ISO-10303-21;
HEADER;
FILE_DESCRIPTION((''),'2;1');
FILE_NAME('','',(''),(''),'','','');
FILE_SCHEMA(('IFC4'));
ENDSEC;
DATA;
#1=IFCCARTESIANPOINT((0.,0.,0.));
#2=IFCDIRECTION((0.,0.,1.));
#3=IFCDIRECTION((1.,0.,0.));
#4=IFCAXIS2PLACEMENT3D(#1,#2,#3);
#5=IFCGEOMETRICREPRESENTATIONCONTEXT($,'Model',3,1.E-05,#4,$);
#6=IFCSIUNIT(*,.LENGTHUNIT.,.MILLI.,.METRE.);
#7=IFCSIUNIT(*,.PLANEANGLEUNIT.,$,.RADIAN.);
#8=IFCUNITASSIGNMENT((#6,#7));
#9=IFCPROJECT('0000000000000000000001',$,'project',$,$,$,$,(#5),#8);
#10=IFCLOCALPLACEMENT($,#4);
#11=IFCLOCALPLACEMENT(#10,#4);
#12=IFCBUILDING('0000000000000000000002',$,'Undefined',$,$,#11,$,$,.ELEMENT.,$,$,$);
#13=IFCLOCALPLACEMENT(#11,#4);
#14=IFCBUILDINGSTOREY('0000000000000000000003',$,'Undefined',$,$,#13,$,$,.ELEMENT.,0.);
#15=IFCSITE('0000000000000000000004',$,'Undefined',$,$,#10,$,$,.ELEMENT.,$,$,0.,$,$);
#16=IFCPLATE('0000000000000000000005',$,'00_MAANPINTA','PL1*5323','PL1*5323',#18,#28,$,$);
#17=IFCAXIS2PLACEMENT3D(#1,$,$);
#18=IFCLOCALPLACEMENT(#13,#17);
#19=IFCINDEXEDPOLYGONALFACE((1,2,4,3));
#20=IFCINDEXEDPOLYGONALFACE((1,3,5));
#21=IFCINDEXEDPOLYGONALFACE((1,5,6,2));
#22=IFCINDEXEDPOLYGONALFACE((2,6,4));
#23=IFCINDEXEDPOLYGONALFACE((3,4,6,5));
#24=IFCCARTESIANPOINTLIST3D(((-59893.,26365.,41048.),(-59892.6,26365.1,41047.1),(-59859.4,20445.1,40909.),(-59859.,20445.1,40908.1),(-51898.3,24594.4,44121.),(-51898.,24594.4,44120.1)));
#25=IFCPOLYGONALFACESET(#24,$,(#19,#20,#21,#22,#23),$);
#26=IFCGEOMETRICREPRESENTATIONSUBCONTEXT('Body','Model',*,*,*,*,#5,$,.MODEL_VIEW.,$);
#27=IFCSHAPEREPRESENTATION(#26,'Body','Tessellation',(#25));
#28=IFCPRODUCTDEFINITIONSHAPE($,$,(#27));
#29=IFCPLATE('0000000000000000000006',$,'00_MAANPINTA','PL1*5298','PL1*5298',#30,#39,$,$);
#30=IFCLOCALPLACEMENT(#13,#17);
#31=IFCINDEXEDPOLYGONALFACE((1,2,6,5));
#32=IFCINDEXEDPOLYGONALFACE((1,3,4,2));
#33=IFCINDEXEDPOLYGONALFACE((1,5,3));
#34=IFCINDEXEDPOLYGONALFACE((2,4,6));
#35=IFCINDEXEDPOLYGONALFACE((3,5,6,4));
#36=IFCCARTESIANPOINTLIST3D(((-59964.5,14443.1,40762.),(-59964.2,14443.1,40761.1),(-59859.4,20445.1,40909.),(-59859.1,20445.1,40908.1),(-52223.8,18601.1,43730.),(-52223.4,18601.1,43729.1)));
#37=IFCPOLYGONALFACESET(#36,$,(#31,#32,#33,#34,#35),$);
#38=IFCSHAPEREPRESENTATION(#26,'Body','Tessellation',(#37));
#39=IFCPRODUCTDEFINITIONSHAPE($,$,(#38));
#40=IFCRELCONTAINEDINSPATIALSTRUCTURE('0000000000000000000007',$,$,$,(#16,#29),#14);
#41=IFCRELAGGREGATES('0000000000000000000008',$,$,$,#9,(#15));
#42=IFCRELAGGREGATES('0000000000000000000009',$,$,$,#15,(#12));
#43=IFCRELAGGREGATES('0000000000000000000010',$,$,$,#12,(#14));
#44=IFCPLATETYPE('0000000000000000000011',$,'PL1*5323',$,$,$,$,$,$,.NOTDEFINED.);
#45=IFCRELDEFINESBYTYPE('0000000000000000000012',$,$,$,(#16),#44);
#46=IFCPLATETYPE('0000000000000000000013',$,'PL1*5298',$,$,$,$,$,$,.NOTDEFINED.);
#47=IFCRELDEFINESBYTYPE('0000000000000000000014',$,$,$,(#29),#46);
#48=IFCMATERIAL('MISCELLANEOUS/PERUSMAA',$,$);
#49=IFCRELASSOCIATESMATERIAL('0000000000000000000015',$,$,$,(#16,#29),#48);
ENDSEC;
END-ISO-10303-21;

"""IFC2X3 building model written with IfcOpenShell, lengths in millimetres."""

from ifc_helpers import new_model, si_unit, frame, origin_with_axes, place, context, subcontext, project, spatial, polyline, outline, extrude, material, type_object, element, save


model = new_model("IFC2X3")

# Units and contexts
model_context = context("Model", 3, precision=1e-05, world=origin_with_axes())
body_context = subcontext(model_context, "Body", "Model", "MODEL_VIEW")
ifc_project = project(units=[si_unit("LENGTHUNIT", "METRE", prefix="MILLI"), si_unit("PLANEANGLEUNIT", "RADIAN")], contexts=[model_context])

# Site, building, storey
site_placement = place(None, origin_with_axes())
site = spatial("IfcSite", under=ifc_project, at=site_placement, Name="Undefined", CompositionType="ELEMENT", RefElevation=0.0)
building_placement = place(site_placement, origin_with_axes())
building = spatial("IfcBuilding", under=site, at=building_placement, Name="Undefined", CompositionType="ELEMENT")
storey_placement = place(building_placement, origin_with_axes())
storey = spatial("IfcBuildingStorey", under=building, at=storey_placement, Name="Undefined", CompositionType="ELEMENT", Elevation=0.0)

# Plates
ifc_material = material(Name="MISCELLANEOUS/PERUSMAA")
plate_type_1 = type_object("IfcPlateType", Name="PL1*5323", PredefinedType="NOTDEFINED")
plate_1_placement = place(storey_placement, frame((-59859.2, 20445.1, 40908.5), z_axis=(0.363301, 0.023928, -0.931365), x_axis=(-0.005667, 0.999708, 0.023473)))
element("IfcPlate", 1, at=plate_1_placement, inside=storey, type_object=plate_type_1, material=ifc_material, Name="00_MAANPINTA", Description="PL1*5323", ObjectType="PL1*5323", context=body_context, shape_type="SweptSolid", body=[
    extrude(outline(polyline([(0.0, 0.0), (5921.7, 0.0), (4178.4, 8570.5), (0.0, 0.0)])), frame((0.0, 0.0, -0.5), z_axis=(0.0, 0.0, 1.0), x_axis=(1.0, 0.0, 0.0)), (0.0, 0.0, 1.0), 1.0),
])
plate_type_2 = type_object("IfcPlateType", Name="PL1*5298", PredefinedType="NOTDEFINED")
plate_2_placement = place(storey_placement, frame((-59964.3, 14443.1, 40761.5), z_axis=(0.350076, 0.016808, -0.93657), x_axis=(0.017502, 0.999547, 0.024481)))
element("IfcPlate", 2, at=plate_2_placement, inside=storey, type_object=plate_type_2, material=ifc_material, Name="00_MAANPINTA", Description="PL1*5298", ObjectType="PL1*5298", context=body_context, shape_type="SweptSolid", body=[
    extrude(outline(polyline([(0.0, 0.0), (6004.7, 0.0), (4364.2, 8183.6), (0.0, 0.0)])), frame((0.0, 0.0, -0.5), z_axis=(0.0, 0.0, 1.0), x_axis=(1.0, 0.0, 0.0)), (0.0, 0.0, 1.0), 1.0),
])

save(model, "model.ifc")
